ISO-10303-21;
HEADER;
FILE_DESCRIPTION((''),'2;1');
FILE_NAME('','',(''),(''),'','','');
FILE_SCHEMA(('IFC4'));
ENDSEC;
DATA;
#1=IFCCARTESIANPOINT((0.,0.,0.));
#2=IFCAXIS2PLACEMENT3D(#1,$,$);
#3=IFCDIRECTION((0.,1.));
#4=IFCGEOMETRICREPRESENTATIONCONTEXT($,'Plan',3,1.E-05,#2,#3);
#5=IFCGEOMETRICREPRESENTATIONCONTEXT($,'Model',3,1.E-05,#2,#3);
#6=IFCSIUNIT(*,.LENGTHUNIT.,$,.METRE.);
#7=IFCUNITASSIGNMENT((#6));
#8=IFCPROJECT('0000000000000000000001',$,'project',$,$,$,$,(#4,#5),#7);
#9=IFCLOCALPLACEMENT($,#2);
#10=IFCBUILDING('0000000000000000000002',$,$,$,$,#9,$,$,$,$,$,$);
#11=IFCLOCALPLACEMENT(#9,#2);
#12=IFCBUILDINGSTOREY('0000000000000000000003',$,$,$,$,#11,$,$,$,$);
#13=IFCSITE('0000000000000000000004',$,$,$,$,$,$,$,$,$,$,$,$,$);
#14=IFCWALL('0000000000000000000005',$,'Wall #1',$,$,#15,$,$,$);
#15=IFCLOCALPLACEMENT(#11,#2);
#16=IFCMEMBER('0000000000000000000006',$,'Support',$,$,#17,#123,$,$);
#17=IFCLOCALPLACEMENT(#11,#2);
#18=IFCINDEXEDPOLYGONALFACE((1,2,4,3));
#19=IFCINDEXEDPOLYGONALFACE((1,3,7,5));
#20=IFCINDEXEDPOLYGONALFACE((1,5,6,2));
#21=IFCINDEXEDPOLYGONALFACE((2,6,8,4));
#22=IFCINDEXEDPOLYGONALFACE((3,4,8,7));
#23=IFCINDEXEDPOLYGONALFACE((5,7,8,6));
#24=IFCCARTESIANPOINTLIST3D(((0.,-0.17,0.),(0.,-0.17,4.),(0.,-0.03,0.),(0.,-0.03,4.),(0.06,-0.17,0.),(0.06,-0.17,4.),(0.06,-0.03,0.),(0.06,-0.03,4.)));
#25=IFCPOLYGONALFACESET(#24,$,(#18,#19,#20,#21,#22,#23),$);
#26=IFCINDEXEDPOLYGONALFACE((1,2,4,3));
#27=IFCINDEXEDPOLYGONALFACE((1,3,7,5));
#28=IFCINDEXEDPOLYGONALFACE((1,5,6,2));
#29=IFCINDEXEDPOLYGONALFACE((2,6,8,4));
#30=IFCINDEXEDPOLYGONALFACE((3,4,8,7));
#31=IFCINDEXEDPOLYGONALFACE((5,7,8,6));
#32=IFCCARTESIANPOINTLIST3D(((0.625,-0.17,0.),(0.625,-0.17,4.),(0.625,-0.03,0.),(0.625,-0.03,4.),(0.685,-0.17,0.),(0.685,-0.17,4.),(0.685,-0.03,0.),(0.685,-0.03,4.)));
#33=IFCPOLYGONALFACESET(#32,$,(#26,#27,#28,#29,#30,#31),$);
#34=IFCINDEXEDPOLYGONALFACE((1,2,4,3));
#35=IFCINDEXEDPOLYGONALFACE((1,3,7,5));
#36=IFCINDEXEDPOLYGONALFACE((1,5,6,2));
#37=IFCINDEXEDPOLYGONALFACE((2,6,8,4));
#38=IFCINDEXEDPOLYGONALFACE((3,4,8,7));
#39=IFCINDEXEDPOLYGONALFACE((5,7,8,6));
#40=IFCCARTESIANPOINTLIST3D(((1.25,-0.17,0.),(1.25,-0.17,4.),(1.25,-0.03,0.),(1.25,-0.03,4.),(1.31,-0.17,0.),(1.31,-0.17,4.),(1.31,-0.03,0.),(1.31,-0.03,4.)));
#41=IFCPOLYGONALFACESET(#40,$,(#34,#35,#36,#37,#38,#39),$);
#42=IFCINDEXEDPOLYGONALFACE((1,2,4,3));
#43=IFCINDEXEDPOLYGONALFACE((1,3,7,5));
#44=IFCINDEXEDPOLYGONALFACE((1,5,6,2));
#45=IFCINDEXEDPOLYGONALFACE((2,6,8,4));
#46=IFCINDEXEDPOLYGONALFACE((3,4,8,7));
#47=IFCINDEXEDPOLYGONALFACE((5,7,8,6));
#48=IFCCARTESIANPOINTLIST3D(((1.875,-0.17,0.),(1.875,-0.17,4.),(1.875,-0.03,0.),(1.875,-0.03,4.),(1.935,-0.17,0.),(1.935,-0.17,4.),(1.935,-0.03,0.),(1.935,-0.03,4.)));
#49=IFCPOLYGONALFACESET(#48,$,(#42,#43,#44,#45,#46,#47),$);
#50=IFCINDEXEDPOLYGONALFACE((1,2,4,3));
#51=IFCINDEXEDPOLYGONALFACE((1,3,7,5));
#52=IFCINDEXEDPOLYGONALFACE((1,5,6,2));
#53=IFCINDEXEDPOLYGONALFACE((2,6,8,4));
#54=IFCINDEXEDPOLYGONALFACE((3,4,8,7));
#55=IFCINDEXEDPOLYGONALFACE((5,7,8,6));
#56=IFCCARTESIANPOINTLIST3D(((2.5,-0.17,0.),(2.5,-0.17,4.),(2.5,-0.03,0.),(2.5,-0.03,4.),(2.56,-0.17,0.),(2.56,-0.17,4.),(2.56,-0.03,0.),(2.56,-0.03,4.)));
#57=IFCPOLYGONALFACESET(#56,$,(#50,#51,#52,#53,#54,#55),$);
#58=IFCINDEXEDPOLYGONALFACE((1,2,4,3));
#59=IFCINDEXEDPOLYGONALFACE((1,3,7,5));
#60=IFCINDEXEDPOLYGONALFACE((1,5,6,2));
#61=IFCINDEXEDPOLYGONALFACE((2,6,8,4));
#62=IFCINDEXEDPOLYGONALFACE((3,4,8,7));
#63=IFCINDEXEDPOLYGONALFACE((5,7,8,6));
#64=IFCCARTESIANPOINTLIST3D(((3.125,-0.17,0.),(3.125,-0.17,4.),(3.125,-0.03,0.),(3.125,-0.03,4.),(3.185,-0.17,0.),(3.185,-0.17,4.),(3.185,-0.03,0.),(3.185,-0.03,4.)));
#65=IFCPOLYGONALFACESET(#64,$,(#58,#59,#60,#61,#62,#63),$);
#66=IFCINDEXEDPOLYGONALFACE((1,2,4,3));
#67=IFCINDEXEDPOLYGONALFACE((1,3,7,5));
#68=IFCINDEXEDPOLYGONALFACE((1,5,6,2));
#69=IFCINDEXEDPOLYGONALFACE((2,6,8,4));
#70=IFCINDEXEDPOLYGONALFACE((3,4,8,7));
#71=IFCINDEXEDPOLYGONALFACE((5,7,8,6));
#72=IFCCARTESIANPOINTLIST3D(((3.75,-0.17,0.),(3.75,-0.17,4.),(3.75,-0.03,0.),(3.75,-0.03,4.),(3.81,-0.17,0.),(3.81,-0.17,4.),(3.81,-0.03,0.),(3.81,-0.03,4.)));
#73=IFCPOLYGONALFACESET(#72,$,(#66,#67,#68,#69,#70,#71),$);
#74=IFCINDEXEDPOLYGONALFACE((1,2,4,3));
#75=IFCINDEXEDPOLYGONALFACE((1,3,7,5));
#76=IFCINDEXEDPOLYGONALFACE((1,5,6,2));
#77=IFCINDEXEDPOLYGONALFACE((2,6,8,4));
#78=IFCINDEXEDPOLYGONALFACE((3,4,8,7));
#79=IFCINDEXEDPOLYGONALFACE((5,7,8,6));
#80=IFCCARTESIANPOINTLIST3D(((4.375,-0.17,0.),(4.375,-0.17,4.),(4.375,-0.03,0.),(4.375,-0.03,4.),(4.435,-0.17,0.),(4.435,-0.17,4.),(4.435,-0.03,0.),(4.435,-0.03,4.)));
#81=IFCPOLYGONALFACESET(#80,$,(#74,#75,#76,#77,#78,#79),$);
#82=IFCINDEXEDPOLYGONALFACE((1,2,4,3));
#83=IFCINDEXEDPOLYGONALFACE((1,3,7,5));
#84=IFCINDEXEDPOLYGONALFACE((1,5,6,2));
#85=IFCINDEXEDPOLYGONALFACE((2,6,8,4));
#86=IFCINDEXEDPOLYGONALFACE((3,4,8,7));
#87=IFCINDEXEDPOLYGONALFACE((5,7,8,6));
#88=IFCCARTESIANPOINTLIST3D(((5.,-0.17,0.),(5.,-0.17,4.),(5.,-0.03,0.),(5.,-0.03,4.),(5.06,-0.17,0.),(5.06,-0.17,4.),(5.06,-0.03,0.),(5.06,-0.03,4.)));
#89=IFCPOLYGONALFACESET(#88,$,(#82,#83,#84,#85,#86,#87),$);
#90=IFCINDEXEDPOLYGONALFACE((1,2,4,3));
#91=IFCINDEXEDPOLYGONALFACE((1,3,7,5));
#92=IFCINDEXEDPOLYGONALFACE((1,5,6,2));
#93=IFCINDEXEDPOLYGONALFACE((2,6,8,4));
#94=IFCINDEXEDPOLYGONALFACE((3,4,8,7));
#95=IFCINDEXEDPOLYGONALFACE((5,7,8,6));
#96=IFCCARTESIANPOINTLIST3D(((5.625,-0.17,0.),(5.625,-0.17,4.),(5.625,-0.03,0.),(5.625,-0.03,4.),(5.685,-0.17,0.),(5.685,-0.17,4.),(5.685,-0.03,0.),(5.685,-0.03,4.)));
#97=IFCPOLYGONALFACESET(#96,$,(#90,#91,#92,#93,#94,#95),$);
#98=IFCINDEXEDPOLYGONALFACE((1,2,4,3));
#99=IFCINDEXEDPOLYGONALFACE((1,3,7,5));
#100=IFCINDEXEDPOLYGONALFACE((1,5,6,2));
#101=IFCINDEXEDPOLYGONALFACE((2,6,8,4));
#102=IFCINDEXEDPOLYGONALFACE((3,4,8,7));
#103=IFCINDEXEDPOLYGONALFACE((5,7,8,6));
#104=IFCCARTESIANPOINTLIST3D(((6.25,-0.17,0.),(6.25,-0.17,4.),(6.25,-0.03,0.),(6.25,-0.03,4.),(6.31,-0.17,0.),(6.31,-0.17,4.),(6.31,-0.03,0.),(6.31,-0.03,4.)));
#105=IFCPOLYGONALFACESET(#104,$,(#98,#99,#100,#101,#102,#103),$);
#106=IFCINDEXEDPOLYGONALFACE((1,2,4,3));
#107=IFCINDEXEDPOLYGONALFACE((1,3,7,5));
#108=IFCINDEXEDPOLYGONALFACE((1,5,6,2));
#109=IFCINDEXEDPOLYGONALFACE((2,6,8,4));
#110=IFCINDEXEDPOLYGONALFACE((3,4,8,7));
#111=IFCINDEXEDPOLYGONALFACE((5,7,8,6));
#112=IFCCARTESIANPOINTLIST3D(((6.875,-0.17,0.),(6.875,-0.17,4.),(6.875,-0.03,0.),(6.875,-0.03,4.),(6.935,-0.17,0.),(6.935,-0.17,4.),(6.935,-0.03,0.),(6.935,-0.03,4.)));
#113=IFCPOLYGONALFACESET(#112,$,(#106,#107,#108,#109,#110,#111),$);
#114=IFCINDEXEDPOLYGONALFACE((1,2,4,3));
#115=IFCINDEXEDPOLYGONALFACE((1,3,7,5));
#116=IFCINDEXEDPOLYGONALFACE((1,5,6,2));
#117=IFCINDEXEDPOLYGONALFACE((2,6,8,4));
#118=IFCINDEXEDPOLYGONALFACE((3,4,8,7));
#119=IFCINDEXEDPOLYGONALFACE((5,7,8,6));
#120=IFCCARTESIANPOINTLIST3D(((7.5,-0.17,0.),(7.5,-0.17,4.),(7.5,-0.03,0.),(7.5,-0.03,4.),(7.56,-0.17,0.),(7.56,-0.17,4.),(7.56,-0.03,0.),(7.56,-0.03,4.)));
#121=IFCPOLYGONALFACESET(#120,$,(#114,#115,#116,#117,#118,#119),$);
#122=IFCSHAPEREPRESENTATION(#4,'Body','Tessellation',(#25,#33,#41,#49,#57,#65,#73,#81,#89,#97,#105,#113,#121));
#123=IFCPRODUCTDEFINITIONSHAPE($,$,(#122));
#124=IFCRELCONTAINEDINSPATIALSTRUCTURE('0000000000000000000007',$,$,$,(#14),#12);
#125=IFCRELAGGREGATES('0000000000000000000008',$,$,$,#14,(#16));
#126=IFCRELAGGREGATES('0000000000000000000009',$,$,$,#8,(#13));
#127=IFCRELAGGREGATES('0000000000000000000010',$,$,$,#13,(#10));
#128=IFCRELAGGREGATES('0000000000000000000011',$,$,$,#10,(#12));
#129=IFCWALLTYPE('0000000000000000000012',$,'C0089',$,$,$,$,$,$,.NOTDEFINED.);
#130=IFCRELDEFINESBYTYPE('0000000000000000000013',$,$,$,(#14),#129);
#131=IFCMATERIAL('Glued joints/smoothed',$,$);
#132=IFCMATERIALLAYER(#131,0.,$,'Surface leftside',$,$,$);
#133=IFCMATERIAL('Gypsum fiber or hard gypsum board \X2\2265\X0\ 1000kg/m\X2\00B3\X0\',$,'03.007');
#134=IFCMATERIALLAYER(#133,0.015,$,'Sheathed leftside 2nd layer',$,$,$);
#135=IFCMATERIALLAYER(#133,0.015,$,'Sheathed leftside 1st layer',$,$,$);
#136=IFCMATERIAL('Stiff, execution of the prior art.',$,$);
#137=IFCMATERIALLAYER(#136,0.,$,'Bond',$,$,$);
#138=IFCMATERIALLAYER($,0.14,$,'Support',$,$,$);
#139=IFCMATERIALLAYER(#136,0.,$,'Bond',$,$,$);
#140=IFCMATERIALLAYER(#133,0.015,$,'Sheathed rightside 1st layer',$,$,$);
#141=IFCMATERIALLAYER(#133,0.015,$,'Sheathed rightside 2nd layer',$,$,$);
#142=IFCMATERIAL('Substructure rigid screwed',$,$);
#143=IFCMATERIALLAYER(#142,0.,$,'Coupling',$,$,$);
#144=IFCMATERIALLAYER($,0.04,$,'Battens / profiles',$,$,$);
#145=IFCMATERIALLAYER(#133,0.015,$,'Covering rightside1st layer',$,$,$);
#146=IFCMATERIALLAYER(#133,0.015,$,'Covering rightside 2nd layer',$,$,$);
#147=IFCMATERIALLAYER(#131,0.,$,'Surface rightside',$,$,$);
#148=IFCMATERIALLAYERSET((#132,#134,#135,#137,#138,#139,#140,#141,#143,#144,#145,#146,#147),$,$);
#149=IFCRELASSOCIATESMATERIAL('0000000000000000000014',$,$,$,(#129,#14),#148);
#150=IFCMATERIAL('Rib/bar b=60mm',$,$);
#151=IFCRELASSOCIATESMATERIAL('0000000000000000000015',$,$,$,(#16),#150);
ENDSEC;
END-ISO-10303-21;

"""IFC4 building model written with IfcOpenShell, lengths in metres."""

from ifc_helpers import new_model, si_unit, direction, frame, frame_2d, origin, place, context, project, spatial, rectangle, extrude, material, layer, layer_set, type_object, element, aggregate, save


model = new_model("IFC4")

# Units and contexts
plan_context = context("Plan", 3, precision=1e-05, world=origin(), true_north=direction((0.0, 1.0)))
model_context = context("Model", 3, precision=1e-05, world=origin(), true_north=direction((0.0, 1.0)))
ifc_project = project(units=[si_unit("LENGTHUNIT", "METRE")], contexts=[plan_context, model_context])

# Site, building, storey
site = spatial("IfcSite", under=ifc_project)
building_placement = place(None, origin())
building = spatial("IfcBuilding", under=site, at=building_placement)
storey_placement = place(building_placement, origin())
storey = spatial("IfcBuildingStorey", under=building, at=storey_placement)

# Wall, member
ifc_material_1 = material(Name="Glued joints/smoothed")
ifc_layer_1 = layer(ifc_material_1, 0.0, Name="Surface leftside")
ifc_material_2 = material(Name="Gypsum fiber or hard gypsum board ≥ 1000kg/m³", Category="03.007")
ifc_layer_2 = layer(ifc_material_2, 0.015, Name="Sheathed leftside 2nd layer")
ifc_layer_3 = layer(ifc_material_2, 0.015, Name="Sheathed leftside 1st layer")
ifc_material_3 = material(Name="Stiff, execution of the prior art.")
ifc_layer_4 = layer(ifc_material_3, 0.0, Name="Bond")
ifc_layer_5 = layer(None, 0.14, Name="Support")
ifc_layer_6 = layer(ifc_material_3, 0.0, Name="Bond")
ifc_layer_7 = layer(ifc_material_2, 0.015, Name="Sheathed rightside 1st layer")
ifc_layer_8 = layer(ifc_material_2, 0.015, Name="Sheathed rightside 2nd layer")
ifc_material_4 = material(Name="Substructure rigid screwed")
ifc_layer_9 = layer(ifc_material_4, 0.0, Name="Coupling")
ifc_layer_10 = layer(None, 0.04, Name="Battens / profiles")
ifc_layer_11 = layer(ifc_material_2, 0.015, Name="Covering rightside1st layer")
ifc_layer_12 = layer(ifc_material_2, 0.015, Name="Covering rightside 2nd layer")
ifc_layer_13 = layer(ifc_material_1, 0.0, Name="Surface rightside")
ifc_layer_set = layer_set([ifc_layer_1, ifc_layer_2, ifc_layer_3, ifc_layer_4, ifc_layer_5, ifc_layer_6, ifc_layer_7, ifc_layer_8, ifc_layer_9, ifc_layer_10, ifc_layer_11, ifc_layer_12, ifc_layer_13])
wall_type = type_object("IfcWallType", Name="C0089", PredefinedType="NOTDEFINED", material=ifc_layer_set)
wall_placement = place(None, frame((0.0, 0.0, 0.0), z_axis=(0.0, -1.0, 0.0), x_axis=(1.0, 0.0, 0.0)))
wall = element("IfcWall", 1, at=wall_placement, inside=storey, type_object=wall_type, material=ifc_layer_set, Name="Wall #1")
ifc_material_5 = material(Name="Rib/bar b=60mm")
member_1_placement = place(wall_placement, origin())
member_1 = element("IfcMember", 2, at=member_1_placement, material=ifc_material_5, Name="Support", context=plan_context, shape_type="SweptSolid", body=[
    extrude(rectangle(XDim=0.06, YDim=0.14, at=frame_2d((0.03, 0.07), x_axis=(1.0, 0.0))), frame((0.0, 4.0, 0.03), z_axis=(0.0, -1.0, 0.0), x_axis=(1.0, 0.0, 0.0)), (0.0, 0.0, 1.0), 4.0),
    extrude(rectangle(XDim=0.06, YDim=0.14, at=frame_2d((0.03, 0.07), x_axis=(1.0, 0.0))), frame((0.625, 4.0, 0.03), z_axis=(0.0, -1.0, 0.0), x_axis=(1.0, 0.0, 0.0)), (0.0, 0.0, 1.0), 4.0),
    extrude(rectangle(XDim=0.06, YDim=0.14, at=frame_2d((0.03, 0.07), x_axis=(1.0, 0.0))), frame((1.25, 4.0, 0.03), z_axis=(0.0, -1.0, 0.0), x_axis=(1.0, 0.0, 0.0)), (0.0, 0.0, 1.0), 4.0),
    extrude(rectangle(XDim=0.06, YDim=0.14, at=frame_2d((0.03, 0.07), x_axis=(1.0, 0.0))), frame((1.875, 4.0, 0.03), z_axis=(0.0, -1.0, 0.0), x_axis=(1.0, 0.0, 0.0)), (0.0, 0.0, 1.0), 4.0),
    extrude(rectangle(XDim=0.06, YDim=0.14, at=frame_2d((0.03, 0.07), x_axis=(1.0, 0.0))), frame((2.5, 4.0, 0.03), z_axis=(0.0, -1.0, 0.0), x_axis=(1.0, 0.0, 0.0)), (0.0, 0.0, 1.0), 4.0),
    extrude(rectangle(XDim=0.06, YDim=0.14, at=frame_2d((0.03, 0.07), x_axis=(1.0, 0.0))), frame((3.125, 4.0, 0.03), z_axis=(0.0, -1.0, 0.0), x_axis=(1.0, 0.0, 0.0)), (0.0, 0.0, 1.0), 4.0),
    extrude(rectangle(XDim=0.06, YDim=0.14, at=frame_2d((0.03, 0.07), x_axis=(1.0, 0.0))), frame((3.75, 4.0, 0.03), z_axis=(0.0, -1.0, 0.0), x_axis=(1.0, 0.0, 0.0)), (0.0, 0.0, 1.0), 4.0),
    extrude(rectangle(XDim=0.06, YDim=0.14, at=frame_2d((0.03, 0.07), x_axis=(1.0, 0.0))), frame((4.375, 4.0, 0.03), z_axis=(0.0, -1.0, 0.0), x_axis=(1.0, 0.0, 0.0)), (0.0, 0.0, 1.0), 4.0),
    extrude(rectangle(XDim=0.06, YDim=0.14, at=frame_2d((0.03, 0.07), x_axis=(1.0, 0.0))), frame((5.0, 4.0, 0.03), z_axis=(0.0, -1.0, 0.0), x_axis=(1.0, 0.0, 0.0)), (0.0, 0.0, 1.0), 4.0),
    extrude(rectangle(XDim=0.06, YDim=0.14, at=frame_2d((0.03, 0.07), x_axis=(1.0, 0.0))), frame((5.625, 4.0, 0.03), z_axis=(0.0, -1.0, 0.0), x_axis=(1.0, 0.0, 0.0)), (0.0, 0.0, 1.0), 4.0),
    extrude(rectangle(XDim=0.06, YDim=0.14, at=frame_2d((0.03, 0.07), x_axis=(1.0, 0.0))), frame((6.25, 4.0, 0.03), z_axis=(0.0, -1.0, 0.0), x_axis=(1.0, 0.0, 0.0)), (0.0, 0.0, 1.0), 4.0),
    extrude(rectangle(XDim=0.06, YDim=0.14, at=frame_2d((0.03, 0.07), x_axis=(1.0, 0.0))), frame((6.875, 4.0, 0.03), z_axis=(0.0, -1.0, 0.0), x_axis=(1.0, 0.0, 0.0)), (0.0, 0.0, 1.0), 4.0),
    extrude(rectangle(XDim=0.06, YDim=0.14, at=frame_2d((0.03, 0.07), x_axis=(1.0, 0.0))), frame((7.5, 4.0, 0.03), z_axis=(0.0, -1.0, 0.0), x_axis=(1.0, 0.0, 0.0)), (0.0, 0.0, 1.0), 4.0),
])
aggregate(wall, [member_1])

save(model, "model.ifc")
